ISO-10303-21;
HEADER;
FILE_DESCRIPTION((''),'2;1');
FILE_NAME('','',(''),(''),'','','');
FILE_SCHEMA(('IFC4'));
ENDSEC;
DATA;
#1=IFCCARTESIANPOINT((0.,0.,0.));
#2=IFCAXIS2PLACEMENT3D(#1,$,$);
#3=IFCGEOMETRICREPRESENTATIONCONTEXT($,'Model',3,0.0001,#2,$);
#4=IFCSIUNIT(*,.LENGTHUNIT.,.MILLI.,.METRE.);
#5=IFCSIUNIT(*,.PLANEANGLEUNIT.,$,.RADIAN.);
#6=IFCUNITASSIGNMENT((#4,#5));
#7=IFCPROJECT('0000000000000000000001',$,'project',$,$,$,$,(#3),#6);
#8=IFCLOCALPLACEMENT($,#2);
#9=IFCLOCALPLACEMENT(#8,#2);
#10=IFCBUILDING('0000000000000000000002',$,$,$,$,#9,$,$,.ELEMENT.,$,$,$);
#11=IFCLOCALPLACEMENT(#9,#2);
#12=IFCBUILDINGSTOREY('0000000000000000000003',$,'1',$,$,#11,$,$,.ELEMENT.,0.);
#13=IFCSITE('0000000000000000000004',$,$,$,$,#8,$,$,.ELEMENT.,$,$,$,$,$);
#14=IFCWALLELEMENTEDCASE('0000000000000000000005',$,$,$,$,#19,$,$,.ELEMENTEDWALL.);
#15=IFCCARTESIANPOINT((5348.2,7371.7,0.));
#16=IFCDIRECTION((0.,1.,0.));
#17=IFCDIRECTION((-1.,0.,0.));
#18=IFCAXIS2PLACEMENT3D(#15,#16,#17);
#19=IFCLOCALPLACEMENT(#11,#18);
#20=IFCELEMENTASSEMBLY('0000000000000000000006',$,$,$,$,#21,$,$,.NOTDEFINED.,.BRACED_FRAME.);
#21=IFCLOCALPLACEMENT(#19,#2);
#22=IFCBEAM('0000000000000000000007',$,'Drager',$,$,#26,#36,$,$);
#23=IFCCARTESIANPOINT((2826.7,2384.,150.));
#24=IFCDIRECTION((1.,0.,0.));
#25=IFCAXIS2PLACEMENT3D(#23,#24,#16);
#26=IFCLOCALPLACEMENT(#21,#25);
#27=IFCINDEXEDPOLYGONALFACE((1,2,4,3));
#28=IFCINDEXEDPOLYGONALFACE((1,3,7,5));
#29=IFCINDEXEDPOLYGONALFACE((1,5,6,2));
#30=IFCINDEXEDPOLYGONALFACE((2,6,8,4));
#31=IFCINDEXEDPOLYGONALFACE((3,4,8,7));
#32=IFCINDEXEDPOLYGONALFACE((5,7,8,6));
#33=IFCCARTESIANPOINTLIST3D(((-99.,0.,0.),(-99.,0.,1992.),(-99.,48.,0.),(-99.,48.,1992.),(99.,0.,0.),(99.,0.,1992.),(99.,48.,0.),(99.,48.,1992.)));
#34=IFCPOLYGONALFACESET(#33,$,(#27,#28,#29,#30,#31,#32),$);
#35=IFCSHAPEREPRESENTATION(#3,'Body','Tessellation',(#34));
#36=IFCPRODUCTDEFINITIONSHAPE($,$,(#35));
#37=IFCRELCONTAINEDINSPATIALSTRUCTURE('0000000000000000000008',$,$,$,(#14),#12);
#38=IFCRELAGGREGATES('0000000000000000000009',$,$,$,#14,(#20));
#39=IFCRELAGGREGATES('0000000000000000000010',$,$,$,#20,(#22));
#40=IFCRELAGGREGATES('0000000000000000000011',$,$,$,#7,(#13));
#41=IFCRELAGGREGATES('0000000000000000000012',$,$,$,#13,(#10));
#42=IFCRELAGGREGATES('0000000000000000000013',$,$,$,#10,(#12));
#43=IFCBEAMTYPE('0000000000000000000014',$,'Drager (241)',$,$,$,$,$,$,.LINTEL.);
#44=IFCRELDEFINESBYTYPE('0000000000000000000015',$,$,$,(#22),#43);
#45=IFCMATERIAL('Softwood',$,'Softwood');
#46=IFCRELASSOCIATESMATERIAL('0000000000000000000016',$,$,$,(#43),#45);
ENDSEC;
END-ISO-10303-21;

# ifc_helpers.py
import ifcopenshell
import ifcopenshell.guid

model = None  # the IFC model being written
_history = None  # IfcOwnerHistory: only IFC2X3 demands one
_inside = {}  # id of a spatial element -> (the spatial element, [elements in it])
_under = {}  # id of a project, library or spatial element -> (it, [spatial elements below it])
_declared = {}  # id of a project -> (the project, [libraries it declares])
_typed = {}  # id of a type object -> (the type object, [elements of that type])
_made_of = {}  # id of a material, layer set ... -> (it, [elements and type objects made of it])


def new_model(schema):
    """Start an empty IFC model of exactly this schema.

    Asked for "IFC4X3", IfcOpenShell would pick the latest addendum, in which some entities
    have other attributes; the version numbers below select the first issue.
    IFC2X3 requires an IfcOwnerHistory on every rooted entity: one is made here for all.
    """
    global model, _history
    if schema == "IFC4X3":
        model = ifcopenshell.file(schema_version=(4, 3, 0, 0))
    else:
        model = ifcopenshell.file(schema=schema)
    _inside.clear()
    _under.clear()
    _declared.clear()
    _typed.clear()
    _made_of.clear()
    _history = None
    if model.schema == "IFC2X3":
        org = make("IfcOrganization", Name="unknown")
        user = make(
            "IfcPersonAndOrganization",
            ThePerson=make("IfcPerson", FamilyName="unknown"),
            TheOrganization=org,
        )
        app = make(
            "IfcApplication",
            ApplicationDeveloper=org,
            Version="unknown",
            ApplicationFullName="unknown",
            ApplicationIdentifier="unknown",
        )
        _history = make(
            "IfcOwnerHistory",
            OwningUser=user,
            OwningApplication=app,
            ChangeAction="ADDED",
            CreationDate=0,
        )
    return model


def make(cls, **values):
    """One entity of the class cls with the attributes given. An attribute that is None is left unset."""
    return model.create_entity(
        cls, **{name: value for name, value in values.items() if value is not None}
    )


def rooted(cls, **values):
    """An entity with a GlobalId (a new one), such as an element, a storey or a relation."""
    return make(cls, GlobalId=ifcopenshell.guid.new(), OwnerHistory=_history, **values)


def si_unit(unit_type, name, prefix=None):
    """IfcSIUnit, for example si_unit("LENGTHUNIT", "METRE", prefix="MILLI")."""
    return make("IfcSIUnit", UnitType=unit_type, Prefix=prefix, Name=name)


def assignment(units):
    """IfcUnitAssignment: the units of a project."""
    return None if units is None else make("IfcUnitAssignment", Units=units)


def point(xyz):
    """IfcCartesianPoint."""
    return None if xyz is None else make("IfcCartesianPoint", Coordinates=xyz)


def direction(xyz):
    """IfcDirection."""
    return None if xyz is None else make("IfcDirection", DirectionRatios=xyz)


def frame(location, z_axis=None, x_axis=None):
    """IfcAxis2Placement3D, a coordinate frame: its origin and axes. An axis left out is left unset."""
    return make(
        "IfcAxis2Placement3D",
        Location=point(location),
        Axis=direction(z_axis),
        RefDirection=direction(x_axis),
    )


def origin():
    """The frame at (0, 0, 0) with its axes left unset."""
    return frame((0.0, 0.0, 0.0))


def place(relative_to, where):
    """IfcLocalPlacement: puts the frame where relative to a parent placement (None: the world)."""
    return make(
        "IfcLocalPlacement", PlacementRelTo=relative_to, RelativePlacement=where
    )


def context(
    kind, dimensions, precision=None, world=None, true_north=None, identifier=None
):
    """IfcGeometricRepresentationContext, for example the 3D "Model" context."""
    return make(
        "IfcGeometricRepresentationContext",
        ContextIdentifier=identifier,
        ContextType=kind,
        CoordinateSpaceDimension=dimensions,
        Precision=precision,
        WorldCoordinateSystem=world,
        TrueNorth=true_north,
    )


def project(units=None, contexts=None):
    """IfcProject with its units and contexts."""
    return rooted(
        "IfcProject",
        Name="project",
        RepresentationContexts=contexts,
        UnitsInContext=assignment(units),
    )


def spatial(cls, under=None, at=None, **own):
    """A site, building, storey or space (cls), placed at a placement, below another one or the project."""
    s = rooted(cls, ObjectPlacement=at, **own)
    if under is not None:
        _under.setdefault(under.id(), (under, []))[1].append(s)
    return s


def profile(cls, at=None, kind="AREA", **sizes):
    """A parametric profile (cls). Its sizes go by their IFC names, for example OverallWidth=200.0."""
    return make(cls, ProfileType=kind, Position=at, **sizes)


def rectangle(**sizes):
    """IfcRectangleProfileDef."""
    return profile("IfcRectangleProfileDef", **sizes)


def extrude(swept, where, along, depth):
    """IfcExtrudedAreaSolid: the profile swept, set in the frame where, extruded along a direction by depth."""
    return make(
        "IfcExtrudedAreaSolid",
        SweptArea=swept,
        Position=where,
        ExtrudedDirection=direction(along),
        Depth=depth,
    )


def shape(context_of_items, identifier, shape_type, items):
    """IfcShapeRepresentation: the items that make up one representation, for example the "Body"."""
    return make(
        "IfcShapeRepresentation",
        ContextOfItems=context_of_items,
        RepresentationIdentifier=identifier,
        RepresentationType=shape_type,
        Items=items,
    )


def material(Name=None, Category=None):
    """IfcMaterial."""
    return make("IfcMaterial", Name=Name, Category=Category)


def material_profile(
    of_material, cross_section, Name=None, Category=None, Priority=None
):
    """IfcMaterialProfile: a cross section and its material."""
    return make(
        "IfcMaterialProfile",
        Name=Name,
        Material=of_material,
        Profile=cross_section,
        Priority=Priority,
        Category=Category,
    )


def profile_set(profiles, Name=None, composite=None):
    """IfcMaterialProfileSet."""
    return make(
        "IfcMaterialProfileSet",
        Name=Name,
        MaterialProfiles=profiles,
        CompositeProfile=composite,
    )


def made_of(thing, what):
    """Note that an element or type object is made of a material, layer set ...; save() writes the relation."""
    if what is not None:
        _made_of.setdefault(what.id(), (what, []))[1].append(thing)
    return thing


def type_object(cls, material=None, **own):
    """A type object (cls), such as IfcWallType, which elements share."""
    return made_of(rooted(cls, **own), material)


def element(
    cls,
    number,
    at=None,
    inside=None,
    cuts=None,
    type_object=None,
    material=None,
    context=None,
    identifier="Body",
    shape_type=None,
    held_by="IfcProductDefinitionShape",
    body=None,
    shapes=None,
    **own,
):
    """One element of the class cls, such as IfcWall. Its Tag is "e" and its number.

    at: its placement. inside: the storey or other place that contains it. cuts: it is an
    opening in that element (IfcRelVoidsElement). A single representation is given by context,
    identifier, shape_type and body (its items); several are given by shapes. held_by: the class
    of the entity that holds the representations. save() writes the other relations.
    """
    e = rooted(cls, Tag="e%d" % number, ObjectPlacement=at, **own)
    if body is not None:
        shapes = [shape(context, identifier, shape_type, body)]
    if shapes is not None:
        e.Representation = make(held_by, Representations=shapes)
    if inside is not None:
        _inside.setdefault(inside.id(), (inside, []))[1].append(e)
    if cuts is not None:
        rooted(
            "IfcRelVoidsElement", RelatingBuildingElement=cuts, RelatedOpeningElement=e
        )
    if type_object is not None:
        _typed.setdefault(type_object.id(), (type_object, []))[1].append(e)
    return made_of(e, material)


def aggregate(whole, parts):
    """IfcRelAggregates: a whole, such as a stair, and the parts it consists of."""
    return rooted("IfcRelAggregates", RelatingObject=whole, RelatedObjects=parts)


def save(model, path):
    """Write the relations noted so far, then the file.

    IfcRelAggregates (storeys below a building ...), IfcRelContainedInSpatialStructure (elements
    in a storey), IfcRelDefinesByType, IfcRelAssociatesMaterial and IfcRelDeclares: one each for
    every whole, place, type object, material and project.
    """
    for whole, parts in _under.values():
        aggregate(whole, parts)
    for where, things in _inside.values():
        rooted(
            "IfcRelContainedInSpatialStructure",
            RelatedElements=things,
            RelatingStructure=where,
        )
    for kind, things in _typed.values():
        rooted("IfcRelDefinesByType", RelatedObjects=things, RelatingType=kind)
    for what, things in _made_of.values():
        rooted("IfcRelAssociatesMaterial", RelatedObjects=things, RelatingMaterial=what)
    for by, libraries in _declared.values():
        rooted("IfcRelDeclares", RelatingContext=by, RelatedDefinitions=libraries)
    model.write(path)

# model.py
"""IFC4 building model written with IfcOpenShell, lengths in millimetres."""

from ifc_helpers import new_model, si_unit, frame, origin, place, context, project, spatial, rectangle, extrude, material, material_profile, profile_set, type_object, element, aggregate, save


model = new_model("IFC4")

# Units and contexts
model_context = context("Model", 3, precision=0.0001, world=origin())
ifc_project = project(units=[si_unit("LENGTHUNIT", "METRE", prefix="MILLI"), si_unit("PLANEANGLEUNIT", "RADIAN")], contexts=[model_context])

# Site, building, storey
site_placement = place(None, origin())
site = spatial("IfcSite", under=ifc_project, at=site_placement, CompositionType="ELEMENT")
building_placement = place(site_placement, origin())
building = spatial("IfcBuilding", under=site, at=building_placement, CompositionType="ELEMENT")
storey_placement = place(building_placement, origin())
storey = spatial("IfcBuildingStorey", under=building, at=storey_placement, Name="1", CompositionType="ELEMENT", Elevation=0.0)

# Wall, element assembly
wall_1_placement = place(storey_placement, frame((5348.2, 7371.7, 0.0), z_axis=(0.0, 1.0, 0.0), x_axis=(-1.0, 0.0, 0.0)))
wall_1 = element("IfcWallElementedCase", 1, at=wall_1_placement, inside=storey, PredefinedType="ELEMENTEDWALL")
assembly_1_placement = place(wall_1_placement, origin())
assembly_1 = element("IfcElementAssembly", 2, at=assembly_1_placement, AssemblyPlace="NOTDEFINED", PredefinedType="BRACED_FRAME")
aggregate(wall_1, [assembly_1])

# Beam
ifc_material_1 = material(Name="Softwood", Category="Softwood")
ifc_material_profile_1 = material_profile(ifc_material_1, rectangle(XDim=198.0, YDim=48.0), Name="Drager (241)")
ifc_profile_set_1 = profile_set([ifc_material_profile_1])
beam_type = type_object("IfcBeamType", Name="Drager (241)", PredefinedType="LINTEL", material=ifc_profile_set_1)
beam_1_placement = place(assembly_1_placement, frame((2826.7, 2384.0, 150.0), z_axis=(1.0, 0.0, 0.0), x_axis=(0.0, 1.0, 0.0)))
beam_1 = element("IfcBeam", 3, at=beam_1_placement, type_object=beam_type, Name="Drager", context=model_context, shape_type="SweptSolid", body=[
    extrude(rectangle(XDim=198.0, YDim=48.0), frame((0.0, 24.0, 0.0)), (0.0, 0.0, 1.0), 1992.0),
])

aggregate(assembly_1, [beam_1])

save(model, "model.ifc")
